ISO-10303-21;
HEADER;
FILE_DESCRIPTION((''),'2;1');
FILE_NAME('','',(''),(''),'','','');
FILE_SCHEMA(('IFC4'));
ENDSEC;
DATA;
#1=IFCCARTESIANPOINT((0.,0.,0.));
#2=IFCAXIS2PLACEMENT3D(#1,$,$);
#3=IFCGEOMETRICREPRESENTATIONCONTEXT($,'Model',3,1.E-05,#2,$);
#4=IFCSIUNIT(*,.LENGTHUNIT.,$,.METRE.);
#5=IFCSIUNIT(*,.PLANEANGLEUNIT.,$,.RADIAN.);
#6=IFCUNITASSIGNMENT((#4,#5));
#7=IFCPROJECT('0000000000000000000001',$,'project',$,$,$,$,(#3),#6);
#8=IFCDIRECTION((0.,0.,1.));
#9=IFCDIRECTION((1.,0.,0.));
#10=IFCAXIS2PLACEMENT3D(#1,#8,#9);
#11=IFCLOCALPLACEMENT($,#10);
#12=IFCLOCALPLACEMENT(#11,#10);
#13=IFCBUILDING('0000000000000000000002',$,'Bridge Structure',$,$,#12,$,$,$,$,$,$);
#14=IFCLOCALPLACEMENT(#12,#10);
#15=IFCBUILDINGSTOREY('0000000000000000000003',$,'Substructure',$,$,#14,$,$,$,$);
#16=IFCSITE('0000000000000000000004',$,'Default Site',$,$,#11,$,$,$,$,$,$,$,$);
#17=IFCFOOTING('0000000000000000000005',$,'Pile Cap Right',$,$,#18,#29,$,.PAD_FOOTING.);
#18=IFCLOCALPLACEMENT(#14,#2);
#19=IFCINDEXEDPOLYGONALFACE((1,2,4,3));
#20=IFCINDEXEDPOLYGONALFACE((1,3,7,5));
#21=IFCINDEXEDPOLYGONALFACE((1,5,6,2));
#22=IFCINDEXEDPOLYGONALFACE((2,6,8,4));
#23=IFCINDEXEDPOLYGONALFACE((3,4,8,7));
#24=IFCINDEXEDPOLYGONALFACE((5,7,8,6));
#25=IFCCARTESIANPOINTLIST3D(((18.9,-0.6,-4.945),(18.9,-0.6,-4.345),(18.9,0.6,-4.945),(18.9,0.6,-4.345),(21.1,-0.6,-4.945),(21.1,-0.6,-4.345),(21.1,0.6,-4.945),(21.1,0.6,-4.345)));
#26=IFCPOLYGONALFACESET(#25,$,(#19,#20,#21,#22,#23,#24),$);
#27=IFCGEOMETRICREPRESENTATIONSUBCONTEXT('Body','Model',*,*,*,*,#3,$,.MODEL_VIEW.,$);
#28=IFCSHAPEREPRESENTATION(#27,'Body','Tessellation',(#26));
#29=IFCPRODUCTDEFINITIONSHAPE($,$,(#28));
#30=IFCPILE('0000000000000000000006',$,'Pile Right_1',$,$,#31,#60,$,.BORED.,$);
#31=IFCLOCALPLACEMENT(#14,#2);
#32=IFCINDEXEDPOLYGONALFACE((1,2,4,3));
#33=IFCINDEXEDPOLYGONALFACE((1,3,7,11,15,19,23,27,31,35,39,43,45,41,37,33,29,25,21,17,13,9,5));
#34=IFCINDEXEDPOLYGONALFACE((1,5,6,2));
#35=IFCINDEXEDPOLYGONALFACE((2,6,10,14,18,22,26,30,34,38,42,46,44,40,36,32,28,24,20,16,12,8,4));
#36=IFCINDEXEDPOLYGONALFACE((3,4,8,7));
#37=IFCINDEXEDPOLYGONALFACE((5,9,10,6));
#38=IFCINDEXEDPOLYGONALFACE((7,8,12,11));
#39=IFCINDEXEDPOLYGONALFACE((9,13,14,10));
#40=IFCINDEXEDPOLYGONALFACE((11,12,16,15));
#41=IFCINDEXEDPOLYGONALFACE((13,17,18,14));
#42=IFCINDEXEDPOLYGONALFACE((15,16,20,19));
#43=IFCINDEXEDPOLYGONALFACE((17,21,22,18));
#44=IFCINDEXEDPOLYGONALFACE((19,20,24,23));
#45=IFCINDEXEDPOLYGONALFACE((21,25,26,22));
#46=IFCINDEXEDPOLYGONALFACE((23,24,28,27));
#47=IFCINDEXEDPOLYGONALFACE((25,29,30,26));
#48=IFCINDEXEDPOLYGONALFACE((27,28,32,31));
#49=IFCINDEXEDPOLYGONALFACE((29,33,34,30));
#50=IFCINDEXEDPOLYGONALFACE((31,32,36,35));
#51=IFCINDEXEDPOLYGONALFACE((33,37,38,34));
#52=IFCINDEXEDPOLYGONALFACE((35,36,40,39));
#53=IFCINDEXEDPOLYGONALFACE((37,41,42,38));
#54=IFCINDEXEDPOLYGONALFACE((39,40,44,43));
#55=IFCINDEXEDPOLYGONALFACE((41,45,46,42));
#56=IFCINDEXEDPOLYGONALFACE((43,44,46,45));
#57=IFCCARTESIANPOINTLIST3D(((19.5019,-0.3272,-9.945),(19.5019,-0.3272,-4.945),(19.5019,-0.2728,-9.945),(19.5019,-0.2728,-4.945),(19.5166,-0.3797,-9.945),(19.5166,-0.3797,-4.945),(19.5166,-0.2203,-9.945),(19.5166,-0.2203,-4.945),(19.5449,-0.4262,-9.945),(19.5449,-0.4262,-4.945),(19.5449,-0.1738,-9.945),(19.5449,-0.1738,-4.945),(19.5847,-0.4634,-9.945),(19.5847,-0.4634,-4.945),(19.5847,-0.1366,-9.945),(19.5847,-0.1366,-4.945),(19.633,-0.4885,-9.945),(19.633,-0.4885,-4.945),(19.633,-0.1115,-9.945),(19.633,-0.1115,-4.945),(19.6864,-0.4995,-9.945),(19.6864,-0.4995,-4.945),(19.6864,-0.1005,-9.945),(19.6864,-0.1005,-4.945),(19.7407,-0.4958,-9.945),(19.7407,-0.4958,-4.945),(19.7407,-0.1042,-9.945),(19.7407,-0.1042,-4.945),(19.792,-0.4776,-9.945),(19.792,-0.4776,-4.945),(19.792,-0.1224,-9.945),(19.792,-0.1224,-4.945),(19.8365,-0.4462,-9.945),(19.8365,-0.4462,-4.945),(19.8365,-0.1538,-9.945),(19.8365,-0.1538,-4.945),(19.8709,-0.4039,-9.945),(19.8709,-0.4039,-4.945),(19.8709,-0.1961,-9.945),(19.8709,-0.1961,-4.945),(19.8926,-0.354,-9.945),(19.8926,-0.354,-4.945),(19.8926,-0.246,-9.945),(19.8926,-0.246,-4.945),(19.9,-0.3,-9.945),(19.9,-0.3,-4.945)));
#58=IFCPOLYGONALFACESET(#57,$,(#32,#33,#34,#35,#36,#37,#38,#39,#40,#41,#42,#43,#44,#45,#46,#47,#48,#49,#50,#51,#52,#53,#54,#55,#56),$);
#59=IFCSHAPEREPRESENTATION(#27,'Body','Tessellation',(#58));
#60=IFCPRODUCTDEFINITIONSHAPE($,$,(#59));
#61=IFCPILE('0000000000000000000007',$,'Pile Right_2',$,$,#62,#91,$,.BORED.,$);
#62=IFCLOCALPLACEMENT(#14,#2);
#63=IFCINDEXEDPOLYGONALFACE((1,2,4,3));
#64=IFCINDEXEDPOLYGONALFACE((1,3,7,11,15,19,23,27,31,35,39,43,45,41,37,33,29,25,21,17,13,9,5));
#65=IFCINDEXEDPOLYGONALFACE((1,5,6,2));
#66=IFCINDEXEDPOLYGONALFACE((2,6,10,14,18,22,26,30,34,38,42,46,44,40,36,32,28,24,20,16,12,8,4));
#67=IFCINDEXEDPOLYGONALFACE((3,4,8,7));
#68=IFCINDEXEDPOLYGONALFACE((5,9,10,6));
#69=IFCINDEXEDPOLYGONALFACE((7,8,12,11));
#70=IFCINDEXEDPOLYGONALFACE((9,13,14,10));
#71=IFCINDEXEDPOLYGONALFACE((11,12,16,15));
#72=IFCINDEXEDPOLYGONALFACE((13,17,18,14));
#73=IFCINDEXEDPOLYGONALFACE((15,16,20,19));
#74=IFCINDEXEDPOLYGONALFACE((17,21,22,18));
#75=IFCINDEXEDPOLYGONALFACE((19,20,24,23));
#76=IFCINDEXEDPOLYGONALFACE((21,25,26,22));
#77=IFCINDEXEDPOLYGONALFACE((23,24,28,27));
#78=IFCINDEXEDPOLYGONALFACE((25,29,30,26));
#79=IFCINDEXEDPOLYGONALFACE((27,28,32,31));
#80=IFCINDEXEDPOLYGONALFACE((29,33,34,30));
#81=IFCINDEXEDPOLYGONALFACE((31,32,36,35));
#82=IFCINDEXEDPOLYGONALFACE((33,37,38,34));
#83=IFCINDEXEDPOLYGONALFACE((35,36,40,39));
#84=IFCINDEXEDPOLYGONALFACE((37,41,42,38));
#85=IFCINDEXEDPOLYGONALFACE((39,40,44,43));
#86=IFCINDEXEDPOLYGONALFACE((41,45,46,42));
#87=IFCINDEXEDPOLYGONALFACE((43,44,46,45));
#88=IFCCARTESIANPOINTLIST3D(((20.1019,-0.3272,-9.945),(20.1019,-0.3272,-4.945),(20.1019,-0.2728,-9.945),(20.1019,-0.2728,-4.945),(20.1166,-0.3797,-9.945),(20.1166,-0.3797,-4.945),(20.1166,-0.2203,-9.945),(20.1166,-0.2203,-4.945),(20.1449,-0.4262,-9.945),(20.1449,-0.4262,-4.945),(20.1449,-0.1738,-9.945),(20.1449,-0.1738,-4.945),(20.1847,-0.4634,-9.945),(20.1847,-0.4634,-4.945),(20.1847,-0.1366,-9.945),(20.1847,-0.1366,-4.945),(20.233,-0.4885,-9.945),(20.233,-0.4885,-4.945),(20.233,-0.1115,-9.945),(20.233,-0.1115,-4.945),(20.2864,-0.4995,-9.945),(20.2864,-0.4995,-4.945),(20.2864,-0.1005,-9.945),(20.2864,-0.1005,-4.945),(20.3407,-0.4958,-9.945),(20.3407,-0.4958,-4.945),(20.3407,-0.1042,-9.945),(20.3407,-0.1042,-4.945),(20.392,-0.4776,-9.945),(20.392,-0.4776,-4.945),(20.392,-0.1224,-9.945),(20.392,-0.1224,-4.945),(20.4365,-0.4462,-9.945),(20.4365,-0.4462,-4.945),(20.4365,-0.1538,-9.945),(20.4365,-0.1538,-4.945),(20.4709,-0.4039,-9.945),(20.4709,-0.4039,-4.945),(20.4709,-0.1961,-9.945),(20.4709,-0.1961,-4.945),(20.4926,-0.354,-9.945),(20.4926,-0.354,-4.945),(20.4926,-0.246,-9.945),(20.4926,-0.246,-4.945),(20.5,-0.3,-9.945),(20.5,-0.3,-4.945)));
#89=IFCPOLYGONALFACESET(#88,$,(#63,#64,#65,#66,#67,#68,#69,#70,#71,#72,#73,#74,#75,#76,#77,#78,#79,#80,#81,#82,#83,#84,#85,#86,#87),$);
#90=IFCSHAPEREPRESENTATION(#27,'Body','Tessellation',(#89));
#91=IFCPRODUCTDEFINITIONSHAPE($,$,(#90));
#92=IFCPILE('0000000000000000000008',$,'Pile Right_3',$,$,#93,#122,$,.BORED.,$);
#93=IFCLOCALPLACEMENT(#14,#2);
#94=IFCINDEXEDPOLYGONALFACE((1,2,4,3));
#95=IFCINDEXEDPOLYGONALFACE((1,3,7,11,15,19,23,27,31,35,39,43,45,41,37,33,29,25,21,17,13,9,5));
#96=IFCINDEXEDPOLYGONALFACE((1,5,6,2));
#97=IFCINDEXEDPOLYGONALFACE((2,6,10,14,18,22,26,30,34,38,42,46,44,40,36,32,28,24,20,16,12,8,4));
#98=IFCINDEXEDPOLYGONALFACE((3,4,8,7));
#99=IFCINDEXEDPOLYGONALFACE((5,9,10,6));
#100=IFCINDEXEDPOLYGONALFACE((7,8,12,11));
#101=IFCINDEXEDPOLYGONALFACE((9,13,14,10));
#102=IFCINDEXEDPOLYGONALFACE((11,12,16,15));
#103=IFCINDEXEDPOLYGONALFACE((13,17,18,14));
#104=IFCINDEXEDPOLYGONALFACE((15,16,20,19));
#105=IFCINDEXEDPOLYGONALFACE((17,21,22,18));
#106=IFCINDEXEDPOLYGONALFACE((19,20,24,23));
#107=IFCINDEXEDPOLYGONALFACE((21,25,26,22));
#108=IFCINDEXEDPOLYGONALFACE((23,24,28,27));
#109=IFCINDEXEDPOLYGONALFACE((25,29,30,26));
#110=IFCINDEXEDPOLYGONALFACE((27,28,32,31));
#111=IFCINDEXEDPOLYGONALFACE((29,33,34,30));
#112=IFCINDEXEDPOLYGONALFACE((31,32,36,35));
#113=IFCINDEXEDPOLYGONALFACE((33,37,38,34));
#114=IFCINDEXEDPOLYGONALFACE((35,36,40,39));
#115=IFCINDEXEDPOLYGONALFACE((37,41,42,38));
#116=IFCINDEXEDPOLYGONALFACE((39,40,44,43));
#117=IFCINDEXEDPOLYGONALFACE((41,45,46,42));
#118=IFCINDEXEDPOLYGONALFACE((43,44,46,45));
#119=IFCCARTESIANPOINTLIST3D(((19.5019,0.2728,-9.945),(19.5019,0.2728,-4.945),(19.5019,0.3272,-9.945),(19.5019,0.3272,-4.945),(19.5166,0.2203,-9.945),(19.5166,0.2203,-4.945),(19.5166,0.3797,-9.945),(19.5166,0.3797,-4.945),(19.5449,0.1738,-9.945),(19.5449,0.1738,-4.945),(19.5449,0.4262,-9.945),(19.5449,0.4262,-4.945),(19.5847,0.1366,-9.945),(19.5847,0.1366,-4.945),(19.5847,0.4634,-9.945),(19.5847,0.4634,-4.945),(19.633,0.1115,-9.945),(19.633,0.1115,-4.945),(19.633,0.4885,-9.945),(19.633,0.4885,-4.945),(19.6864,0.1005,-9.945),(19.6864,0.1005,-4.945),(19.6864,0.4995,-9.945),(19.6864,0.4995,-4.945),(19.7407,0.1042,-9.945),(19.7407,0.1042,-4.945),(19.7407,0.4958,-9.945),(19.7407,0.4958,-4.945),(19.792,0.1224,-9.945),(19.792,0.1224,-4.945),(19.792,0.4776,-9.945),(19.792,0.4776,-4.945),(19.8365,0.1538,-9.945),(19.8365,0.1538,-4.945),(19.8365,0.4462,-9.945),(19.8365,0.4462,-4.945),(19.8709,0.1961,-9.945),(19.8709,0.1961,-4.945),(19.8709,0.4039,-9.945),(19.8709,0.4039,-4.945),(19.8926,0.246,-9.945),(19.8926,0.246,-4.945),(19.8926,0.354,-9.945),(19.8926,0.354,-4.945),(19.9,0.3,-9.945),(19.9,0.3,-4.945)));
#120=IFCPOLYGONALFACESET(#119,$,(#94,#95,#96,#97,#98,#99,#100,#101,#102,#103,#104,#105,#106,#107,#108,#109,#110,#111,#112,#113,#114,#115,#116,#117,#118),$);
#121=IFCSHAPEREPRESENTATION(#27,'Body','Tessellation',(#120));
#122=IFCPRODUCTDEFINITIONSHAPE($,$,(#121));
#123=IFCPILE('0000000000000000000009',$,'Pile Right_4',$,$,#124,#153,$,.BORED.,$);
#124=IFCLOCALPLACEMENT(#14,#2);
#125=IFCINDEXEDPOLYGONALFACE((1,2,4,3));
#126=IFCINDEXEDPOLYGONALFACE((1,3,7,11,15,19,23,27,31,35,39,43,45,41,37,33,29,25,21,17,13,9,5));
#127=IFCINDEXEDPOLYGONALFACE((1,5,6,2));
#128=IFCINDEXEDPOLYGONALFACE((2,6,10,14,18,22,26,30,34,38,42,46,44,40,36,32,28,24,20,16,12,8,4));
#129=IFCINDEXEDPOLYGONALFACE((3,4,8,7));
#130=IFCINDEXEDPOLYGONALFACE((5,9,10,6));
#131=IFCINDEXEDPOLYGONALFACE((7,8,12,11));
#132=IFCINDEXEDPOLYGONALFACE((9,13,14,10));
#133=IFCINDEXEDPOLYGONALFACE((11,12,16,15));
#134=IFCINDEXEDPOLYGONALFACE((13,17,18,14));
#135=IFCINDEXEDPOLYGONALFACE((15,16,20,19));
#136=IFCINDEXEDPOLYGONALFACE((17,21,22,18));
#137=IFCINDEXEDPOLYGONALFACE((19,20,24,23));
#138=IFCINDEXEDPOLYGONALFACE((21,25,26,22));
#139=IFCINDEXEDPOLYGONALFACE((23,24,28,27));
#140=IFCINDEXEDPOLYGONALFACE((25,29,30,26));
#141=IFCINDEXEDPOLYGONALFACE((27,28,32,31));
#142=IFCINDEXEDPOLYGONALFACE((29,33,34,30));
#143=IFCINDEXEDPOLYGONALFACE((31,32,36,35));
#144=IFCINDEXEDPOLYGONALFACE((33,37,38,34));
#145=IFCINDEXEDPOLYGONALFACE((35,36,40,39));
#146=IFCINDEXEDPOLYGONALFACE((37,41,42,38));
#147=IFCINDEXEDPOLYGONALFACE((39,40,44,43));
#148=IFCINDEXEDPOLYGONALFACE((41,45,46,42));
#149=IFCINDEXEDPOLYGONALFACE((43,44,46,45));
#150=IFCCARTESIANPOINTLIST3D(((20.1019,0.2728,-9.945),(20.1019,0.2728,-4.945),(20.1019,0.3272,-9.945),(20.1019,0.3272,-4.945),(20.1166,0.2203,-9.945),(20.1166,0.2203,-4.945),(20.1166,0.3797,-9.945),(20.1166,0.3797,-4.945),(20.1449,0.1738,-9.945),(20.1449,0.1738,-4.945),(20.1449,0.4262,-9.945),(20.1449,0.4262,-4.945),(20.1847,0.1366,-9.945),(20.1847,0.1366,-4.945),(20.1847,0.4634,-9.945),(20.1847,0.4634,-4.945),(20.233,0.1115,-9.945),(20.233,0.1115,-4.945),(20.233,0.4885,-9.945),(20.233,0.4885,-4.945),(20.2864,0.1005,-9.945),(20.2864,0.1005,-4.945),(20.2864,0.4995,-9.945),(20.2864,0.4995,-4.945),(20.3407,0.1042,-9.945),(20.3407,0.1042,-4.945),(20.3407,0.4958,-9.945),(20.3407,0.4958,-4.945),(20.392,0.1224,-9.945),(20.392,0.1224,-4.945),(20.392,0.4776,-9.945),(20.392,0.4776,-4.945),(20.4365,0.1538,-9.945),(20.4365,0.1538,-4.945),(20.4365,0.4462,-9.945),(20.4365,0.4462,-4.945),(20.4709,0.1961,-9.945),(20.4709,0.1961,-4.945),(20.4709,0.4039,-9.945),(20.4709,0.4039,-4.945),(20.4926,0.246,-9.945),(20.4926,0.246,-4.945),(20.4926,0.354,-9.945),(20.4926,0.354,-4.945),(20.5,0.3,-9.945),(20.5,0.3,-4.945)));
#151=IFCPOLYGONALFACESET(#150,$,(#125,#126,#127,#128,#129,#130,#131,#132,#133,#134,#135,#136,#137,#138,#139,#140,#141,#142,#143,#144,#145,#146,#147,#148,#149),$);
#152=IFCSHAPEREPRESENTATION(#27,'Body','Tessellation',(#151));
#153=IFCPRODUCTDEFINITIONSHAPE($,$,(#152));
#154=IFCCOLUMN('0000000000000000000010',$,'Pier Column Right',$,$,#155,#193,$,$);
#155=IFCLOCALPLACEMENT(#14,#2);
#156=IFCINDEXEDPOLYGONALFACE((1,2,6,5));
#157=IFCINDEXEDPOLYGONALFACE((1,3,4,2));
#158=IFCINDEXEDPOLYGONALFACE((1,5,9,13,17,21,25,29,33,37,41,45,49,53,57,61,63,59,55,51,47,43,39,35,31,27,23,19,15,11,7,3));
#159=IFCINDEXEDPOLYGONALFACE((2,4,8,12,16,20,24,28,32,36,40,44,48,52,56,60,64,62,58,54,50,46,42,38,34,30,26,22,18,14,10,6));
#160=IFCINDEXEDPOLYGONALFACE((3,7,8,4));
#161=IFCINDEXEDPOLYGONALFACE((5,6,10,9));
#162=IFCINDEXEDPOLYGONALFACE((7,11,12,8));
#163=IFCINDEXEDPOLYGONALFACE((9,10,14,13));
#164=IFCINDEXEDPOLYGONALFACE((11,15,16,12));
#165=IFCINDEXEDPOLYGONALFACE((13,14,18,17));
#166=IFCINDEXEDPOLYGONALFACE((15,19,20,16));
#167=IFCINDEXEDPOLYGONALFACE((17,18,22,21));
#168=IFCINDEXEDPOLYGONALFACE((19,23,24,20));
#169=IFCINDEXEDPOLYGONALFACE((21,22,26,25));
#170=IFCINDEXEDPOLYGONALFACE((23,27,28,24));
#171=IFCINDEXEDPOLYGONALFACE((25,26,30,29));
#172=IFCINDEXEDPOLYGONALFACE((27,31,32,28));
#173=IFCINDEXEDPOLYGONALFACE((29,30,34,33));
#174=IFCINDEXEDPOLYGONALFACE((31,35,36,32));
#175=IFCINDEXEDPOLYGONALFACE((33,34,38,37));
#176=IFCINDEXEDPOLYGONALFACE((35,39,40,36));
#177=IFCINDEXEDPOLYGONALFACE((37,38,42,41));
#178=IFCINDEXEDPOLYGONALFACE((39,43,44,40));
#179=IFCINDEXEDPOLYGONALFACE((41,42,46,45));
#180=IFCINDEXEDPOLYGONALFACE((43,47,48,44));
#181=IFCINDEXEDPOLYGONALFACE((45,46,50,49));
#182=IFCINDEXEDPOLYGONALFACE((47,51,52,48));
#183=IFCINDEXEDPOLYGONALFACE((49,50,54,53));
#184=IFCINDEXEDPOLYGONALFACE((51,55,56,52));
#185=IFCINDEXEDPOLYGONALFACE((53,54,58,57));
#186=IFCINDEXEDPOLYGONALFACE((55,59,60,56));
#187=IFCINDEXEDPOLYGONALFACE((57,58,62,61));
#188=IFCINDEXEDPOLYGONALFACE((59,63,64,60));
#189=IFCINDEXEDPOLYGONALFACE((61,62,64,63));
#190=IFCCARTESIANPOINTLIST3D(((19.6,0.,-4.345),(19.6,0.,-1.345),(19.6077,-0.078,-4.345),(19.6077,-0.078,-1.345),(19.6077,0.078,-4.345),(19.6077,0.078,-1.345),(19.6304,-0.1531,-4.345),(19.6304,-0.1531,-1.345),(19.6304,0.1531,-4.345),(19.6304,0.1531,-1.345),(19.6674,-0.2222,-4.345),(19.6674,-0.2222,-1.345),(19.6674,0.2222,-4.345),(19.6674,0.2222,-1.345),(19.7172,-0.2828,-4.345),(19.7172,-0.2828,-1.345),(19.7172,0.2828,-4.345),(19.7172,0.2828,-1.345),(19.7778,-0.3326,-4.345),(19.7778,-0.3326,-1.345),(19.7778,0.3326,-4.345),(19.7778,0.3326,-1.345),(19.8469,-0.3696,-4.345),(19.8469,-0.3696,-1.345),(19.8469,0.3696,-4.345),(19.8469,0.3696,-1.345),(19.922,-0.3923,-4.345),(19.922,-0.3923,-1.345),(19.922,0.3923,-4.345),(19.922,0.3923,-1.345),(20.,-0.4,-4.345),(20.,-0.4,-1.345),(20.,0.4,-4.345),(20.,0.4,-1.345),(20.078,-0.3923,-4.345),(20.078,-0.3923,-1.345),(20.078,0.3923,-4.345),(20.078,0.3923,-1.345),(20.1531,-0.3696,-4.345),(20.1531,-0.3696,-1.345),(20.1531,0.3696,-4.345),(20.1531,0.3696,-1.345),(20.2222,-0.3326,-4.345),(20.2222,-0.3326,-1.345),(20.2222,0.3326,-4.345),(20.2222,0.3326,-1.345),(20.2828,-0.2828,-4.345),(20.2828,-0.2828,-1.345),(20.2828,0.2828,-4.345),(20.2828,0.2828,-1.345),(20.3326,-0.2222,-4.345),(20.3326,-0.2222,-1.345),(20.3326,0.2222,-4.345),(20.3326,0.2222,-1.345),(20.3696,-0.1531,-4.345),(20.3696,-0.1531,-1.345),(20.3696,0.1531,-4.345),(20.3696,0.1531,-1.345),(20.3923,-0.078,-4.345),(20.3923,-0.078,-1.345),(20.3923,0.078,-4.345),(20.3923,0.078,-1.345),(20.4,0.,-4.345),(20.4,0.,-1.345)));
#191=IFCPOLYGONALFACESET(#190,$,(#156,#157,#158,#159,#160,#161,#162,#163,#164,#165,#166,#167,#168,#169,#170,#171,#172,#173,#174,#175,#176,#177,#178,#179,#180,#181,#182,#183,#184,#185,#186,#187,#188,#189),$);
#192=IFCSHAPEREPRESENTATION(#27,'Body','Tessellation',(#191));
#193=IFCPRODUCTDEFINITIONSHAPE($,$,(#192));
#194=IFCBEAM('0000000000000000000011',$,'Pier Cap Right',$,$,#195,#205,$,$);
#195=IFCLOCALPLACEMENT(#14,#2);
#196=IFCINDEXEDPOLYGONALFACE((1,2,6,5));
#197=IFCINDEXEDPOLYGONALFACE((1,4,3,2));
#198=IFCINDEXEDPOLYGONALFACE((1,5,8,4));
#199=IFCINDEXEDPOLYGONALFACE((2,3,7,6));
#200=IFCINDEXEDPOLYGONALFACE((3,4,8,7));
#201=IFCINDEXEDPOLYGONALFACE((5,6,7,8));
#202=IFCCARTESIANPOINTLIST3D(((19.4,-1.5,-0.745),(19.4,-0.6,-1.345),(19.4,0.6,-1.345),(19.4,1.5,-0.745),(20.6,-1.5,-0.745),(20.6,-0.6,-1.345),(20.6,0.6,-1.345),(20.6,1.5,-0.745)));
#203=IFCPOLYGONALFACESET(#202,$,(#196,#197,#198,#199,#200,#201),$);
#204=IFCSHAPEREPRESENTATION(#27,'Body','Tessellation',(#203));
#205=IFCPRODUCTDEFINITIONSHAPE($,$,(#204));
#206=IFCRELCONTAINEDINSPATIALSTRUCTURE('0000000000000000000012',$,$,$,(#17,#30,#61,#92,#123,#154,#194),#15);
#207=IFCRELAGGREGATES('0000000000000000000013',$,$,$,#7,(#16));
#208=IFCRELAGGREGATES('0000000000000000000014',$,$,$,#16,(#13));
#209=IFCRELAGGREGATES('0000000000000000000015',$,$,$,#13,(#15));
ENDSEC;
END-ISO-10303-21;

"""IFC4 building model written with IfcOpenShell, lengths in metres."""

from ifc_helpers import new_model, si_unit, frame, origin, origin_with_axes, origin_2d_with_axis, place, context, subcontext, project, spatial, polyline, rectangle, circle, outline, extrude, element, save


model = new_model("IFC4")

# Units and contexts
model_context = context("Model", 3, precision=1e-05, world=origin())
body_context = subcontext(model_context, "Body", "Model", "MODEL_VIEW")
ifc_project = project(units=[si_unit("LENGTHUNIT", "METRE"), si_unit("PLANEANGLEUNIT", "RADIAN")], contexts=[model_context])

# Site, building, storey
site_placement = place(None, origin_with_axes())
site = spatial("IfcSite", under=ifc_project, at=site_placement, Name="Default Site")
building_placement = place(site_placement, origin_with_axes())
building = spatial("IfcBuilding", under=site, at=building_placement, Name="Bridge Structure")
storey_placement = place(building_placement, origin_with_axes())
storey = spatial("IfcBuildingStorey", under=building, at=storey_placement, Name="Substructure")

# Footing
footing_placement = place(storey_placement, frame((20.0, 0.0, -4.945), z_axis=(0.0, 0.0, 1.0), x_axis=(1.0, 0.0, 0.0)))
element("IfcFooting", 1, at=footing_placement, inside=storey, Name="Pile Cap Right", PredefinedType="PAD_FOOTING", context=body_context, shape_type="SweptSolid", body=[
    extrude(rectangle(XDim=2.2, YDim=1.2, at=origin_2d_with_axis()), origin_with_axes(), (0.0, 0.0, 1.0), 0.6),
])

# Piles
for number, where, z_axis, x_axis, name in (
    (2, (19.7, -0.3, -9.945), (0.0, 0.0, 1.0), (1.0, 0.0, 0.0), "Pile Right_1"),
    (3, (20.3, -0.3, -9.945), (0.0, 0.0, 1.0), (1.0, 0.0, 0.0), "Pile Right_2"),
    (4, (19.7, 0.3, -9.945), (0.0, 0.0, 1.0), (1.0, 0.0, 0.0), "Pile Right_3"),
    (5, (20.3, 0.3, -9.945), (0.0, 0.0, 1.0), (1.0, 0.0, 0.0), "Pile Right_4"),
):
    element("IfcPile", number, at=place(storey_placement, frame(where, z_axis=z_axis, x_axis=x_axis)), inside=storey, Name=name, PredefinedType="BORED", context=body_context, shape_type="SweptSolid", body=[
        extrude(circle(Radius=0.2, at=origin_2d_with_axis()), origin_with_axes(), (0.0, 0.0, 1.0), 5.0),
    ])

# Column
column_placement = place(storey_placement, frame((20.0, 0.0, -4.345), z_axis=(0.0, 0.0, 1.0), x_axis=(1.0, 0.0, 0.0)))
element("IfcColumn", 6, at=column_placement, inside=storey, Name="Pier Column Right", context=body_context, shape_type="SweptSolid", body=[
    extrude(circle(Radius=0.4, at=origin_2d_with_axis()), origin_with_axes(), (0.0, 0.0, 1.0), 3.0),
])

# Beam
beam_placement = place(storey_placement, frame((19.4, 0.0, -1.345), z_axis=(1.0, 0.0, 0.0), x_axis=(0.0, 1.0, 0.0)))
element("IfcBeam", 7, at=beam_placement, inside=storey, Name="Pier Cap Right", context=body_context, shape_type="SweptSolid", body=[
    extrude(outline(polyline([(-1.5, 0.6), (1.5, 0.6), (0.6, 0.0), (-0.6, 0.0), (-1.5, 0.6)])), origin_with_axes(), (0.0, 0.0, 1.0), 1.2),
])

save(model, "model.ifc")
